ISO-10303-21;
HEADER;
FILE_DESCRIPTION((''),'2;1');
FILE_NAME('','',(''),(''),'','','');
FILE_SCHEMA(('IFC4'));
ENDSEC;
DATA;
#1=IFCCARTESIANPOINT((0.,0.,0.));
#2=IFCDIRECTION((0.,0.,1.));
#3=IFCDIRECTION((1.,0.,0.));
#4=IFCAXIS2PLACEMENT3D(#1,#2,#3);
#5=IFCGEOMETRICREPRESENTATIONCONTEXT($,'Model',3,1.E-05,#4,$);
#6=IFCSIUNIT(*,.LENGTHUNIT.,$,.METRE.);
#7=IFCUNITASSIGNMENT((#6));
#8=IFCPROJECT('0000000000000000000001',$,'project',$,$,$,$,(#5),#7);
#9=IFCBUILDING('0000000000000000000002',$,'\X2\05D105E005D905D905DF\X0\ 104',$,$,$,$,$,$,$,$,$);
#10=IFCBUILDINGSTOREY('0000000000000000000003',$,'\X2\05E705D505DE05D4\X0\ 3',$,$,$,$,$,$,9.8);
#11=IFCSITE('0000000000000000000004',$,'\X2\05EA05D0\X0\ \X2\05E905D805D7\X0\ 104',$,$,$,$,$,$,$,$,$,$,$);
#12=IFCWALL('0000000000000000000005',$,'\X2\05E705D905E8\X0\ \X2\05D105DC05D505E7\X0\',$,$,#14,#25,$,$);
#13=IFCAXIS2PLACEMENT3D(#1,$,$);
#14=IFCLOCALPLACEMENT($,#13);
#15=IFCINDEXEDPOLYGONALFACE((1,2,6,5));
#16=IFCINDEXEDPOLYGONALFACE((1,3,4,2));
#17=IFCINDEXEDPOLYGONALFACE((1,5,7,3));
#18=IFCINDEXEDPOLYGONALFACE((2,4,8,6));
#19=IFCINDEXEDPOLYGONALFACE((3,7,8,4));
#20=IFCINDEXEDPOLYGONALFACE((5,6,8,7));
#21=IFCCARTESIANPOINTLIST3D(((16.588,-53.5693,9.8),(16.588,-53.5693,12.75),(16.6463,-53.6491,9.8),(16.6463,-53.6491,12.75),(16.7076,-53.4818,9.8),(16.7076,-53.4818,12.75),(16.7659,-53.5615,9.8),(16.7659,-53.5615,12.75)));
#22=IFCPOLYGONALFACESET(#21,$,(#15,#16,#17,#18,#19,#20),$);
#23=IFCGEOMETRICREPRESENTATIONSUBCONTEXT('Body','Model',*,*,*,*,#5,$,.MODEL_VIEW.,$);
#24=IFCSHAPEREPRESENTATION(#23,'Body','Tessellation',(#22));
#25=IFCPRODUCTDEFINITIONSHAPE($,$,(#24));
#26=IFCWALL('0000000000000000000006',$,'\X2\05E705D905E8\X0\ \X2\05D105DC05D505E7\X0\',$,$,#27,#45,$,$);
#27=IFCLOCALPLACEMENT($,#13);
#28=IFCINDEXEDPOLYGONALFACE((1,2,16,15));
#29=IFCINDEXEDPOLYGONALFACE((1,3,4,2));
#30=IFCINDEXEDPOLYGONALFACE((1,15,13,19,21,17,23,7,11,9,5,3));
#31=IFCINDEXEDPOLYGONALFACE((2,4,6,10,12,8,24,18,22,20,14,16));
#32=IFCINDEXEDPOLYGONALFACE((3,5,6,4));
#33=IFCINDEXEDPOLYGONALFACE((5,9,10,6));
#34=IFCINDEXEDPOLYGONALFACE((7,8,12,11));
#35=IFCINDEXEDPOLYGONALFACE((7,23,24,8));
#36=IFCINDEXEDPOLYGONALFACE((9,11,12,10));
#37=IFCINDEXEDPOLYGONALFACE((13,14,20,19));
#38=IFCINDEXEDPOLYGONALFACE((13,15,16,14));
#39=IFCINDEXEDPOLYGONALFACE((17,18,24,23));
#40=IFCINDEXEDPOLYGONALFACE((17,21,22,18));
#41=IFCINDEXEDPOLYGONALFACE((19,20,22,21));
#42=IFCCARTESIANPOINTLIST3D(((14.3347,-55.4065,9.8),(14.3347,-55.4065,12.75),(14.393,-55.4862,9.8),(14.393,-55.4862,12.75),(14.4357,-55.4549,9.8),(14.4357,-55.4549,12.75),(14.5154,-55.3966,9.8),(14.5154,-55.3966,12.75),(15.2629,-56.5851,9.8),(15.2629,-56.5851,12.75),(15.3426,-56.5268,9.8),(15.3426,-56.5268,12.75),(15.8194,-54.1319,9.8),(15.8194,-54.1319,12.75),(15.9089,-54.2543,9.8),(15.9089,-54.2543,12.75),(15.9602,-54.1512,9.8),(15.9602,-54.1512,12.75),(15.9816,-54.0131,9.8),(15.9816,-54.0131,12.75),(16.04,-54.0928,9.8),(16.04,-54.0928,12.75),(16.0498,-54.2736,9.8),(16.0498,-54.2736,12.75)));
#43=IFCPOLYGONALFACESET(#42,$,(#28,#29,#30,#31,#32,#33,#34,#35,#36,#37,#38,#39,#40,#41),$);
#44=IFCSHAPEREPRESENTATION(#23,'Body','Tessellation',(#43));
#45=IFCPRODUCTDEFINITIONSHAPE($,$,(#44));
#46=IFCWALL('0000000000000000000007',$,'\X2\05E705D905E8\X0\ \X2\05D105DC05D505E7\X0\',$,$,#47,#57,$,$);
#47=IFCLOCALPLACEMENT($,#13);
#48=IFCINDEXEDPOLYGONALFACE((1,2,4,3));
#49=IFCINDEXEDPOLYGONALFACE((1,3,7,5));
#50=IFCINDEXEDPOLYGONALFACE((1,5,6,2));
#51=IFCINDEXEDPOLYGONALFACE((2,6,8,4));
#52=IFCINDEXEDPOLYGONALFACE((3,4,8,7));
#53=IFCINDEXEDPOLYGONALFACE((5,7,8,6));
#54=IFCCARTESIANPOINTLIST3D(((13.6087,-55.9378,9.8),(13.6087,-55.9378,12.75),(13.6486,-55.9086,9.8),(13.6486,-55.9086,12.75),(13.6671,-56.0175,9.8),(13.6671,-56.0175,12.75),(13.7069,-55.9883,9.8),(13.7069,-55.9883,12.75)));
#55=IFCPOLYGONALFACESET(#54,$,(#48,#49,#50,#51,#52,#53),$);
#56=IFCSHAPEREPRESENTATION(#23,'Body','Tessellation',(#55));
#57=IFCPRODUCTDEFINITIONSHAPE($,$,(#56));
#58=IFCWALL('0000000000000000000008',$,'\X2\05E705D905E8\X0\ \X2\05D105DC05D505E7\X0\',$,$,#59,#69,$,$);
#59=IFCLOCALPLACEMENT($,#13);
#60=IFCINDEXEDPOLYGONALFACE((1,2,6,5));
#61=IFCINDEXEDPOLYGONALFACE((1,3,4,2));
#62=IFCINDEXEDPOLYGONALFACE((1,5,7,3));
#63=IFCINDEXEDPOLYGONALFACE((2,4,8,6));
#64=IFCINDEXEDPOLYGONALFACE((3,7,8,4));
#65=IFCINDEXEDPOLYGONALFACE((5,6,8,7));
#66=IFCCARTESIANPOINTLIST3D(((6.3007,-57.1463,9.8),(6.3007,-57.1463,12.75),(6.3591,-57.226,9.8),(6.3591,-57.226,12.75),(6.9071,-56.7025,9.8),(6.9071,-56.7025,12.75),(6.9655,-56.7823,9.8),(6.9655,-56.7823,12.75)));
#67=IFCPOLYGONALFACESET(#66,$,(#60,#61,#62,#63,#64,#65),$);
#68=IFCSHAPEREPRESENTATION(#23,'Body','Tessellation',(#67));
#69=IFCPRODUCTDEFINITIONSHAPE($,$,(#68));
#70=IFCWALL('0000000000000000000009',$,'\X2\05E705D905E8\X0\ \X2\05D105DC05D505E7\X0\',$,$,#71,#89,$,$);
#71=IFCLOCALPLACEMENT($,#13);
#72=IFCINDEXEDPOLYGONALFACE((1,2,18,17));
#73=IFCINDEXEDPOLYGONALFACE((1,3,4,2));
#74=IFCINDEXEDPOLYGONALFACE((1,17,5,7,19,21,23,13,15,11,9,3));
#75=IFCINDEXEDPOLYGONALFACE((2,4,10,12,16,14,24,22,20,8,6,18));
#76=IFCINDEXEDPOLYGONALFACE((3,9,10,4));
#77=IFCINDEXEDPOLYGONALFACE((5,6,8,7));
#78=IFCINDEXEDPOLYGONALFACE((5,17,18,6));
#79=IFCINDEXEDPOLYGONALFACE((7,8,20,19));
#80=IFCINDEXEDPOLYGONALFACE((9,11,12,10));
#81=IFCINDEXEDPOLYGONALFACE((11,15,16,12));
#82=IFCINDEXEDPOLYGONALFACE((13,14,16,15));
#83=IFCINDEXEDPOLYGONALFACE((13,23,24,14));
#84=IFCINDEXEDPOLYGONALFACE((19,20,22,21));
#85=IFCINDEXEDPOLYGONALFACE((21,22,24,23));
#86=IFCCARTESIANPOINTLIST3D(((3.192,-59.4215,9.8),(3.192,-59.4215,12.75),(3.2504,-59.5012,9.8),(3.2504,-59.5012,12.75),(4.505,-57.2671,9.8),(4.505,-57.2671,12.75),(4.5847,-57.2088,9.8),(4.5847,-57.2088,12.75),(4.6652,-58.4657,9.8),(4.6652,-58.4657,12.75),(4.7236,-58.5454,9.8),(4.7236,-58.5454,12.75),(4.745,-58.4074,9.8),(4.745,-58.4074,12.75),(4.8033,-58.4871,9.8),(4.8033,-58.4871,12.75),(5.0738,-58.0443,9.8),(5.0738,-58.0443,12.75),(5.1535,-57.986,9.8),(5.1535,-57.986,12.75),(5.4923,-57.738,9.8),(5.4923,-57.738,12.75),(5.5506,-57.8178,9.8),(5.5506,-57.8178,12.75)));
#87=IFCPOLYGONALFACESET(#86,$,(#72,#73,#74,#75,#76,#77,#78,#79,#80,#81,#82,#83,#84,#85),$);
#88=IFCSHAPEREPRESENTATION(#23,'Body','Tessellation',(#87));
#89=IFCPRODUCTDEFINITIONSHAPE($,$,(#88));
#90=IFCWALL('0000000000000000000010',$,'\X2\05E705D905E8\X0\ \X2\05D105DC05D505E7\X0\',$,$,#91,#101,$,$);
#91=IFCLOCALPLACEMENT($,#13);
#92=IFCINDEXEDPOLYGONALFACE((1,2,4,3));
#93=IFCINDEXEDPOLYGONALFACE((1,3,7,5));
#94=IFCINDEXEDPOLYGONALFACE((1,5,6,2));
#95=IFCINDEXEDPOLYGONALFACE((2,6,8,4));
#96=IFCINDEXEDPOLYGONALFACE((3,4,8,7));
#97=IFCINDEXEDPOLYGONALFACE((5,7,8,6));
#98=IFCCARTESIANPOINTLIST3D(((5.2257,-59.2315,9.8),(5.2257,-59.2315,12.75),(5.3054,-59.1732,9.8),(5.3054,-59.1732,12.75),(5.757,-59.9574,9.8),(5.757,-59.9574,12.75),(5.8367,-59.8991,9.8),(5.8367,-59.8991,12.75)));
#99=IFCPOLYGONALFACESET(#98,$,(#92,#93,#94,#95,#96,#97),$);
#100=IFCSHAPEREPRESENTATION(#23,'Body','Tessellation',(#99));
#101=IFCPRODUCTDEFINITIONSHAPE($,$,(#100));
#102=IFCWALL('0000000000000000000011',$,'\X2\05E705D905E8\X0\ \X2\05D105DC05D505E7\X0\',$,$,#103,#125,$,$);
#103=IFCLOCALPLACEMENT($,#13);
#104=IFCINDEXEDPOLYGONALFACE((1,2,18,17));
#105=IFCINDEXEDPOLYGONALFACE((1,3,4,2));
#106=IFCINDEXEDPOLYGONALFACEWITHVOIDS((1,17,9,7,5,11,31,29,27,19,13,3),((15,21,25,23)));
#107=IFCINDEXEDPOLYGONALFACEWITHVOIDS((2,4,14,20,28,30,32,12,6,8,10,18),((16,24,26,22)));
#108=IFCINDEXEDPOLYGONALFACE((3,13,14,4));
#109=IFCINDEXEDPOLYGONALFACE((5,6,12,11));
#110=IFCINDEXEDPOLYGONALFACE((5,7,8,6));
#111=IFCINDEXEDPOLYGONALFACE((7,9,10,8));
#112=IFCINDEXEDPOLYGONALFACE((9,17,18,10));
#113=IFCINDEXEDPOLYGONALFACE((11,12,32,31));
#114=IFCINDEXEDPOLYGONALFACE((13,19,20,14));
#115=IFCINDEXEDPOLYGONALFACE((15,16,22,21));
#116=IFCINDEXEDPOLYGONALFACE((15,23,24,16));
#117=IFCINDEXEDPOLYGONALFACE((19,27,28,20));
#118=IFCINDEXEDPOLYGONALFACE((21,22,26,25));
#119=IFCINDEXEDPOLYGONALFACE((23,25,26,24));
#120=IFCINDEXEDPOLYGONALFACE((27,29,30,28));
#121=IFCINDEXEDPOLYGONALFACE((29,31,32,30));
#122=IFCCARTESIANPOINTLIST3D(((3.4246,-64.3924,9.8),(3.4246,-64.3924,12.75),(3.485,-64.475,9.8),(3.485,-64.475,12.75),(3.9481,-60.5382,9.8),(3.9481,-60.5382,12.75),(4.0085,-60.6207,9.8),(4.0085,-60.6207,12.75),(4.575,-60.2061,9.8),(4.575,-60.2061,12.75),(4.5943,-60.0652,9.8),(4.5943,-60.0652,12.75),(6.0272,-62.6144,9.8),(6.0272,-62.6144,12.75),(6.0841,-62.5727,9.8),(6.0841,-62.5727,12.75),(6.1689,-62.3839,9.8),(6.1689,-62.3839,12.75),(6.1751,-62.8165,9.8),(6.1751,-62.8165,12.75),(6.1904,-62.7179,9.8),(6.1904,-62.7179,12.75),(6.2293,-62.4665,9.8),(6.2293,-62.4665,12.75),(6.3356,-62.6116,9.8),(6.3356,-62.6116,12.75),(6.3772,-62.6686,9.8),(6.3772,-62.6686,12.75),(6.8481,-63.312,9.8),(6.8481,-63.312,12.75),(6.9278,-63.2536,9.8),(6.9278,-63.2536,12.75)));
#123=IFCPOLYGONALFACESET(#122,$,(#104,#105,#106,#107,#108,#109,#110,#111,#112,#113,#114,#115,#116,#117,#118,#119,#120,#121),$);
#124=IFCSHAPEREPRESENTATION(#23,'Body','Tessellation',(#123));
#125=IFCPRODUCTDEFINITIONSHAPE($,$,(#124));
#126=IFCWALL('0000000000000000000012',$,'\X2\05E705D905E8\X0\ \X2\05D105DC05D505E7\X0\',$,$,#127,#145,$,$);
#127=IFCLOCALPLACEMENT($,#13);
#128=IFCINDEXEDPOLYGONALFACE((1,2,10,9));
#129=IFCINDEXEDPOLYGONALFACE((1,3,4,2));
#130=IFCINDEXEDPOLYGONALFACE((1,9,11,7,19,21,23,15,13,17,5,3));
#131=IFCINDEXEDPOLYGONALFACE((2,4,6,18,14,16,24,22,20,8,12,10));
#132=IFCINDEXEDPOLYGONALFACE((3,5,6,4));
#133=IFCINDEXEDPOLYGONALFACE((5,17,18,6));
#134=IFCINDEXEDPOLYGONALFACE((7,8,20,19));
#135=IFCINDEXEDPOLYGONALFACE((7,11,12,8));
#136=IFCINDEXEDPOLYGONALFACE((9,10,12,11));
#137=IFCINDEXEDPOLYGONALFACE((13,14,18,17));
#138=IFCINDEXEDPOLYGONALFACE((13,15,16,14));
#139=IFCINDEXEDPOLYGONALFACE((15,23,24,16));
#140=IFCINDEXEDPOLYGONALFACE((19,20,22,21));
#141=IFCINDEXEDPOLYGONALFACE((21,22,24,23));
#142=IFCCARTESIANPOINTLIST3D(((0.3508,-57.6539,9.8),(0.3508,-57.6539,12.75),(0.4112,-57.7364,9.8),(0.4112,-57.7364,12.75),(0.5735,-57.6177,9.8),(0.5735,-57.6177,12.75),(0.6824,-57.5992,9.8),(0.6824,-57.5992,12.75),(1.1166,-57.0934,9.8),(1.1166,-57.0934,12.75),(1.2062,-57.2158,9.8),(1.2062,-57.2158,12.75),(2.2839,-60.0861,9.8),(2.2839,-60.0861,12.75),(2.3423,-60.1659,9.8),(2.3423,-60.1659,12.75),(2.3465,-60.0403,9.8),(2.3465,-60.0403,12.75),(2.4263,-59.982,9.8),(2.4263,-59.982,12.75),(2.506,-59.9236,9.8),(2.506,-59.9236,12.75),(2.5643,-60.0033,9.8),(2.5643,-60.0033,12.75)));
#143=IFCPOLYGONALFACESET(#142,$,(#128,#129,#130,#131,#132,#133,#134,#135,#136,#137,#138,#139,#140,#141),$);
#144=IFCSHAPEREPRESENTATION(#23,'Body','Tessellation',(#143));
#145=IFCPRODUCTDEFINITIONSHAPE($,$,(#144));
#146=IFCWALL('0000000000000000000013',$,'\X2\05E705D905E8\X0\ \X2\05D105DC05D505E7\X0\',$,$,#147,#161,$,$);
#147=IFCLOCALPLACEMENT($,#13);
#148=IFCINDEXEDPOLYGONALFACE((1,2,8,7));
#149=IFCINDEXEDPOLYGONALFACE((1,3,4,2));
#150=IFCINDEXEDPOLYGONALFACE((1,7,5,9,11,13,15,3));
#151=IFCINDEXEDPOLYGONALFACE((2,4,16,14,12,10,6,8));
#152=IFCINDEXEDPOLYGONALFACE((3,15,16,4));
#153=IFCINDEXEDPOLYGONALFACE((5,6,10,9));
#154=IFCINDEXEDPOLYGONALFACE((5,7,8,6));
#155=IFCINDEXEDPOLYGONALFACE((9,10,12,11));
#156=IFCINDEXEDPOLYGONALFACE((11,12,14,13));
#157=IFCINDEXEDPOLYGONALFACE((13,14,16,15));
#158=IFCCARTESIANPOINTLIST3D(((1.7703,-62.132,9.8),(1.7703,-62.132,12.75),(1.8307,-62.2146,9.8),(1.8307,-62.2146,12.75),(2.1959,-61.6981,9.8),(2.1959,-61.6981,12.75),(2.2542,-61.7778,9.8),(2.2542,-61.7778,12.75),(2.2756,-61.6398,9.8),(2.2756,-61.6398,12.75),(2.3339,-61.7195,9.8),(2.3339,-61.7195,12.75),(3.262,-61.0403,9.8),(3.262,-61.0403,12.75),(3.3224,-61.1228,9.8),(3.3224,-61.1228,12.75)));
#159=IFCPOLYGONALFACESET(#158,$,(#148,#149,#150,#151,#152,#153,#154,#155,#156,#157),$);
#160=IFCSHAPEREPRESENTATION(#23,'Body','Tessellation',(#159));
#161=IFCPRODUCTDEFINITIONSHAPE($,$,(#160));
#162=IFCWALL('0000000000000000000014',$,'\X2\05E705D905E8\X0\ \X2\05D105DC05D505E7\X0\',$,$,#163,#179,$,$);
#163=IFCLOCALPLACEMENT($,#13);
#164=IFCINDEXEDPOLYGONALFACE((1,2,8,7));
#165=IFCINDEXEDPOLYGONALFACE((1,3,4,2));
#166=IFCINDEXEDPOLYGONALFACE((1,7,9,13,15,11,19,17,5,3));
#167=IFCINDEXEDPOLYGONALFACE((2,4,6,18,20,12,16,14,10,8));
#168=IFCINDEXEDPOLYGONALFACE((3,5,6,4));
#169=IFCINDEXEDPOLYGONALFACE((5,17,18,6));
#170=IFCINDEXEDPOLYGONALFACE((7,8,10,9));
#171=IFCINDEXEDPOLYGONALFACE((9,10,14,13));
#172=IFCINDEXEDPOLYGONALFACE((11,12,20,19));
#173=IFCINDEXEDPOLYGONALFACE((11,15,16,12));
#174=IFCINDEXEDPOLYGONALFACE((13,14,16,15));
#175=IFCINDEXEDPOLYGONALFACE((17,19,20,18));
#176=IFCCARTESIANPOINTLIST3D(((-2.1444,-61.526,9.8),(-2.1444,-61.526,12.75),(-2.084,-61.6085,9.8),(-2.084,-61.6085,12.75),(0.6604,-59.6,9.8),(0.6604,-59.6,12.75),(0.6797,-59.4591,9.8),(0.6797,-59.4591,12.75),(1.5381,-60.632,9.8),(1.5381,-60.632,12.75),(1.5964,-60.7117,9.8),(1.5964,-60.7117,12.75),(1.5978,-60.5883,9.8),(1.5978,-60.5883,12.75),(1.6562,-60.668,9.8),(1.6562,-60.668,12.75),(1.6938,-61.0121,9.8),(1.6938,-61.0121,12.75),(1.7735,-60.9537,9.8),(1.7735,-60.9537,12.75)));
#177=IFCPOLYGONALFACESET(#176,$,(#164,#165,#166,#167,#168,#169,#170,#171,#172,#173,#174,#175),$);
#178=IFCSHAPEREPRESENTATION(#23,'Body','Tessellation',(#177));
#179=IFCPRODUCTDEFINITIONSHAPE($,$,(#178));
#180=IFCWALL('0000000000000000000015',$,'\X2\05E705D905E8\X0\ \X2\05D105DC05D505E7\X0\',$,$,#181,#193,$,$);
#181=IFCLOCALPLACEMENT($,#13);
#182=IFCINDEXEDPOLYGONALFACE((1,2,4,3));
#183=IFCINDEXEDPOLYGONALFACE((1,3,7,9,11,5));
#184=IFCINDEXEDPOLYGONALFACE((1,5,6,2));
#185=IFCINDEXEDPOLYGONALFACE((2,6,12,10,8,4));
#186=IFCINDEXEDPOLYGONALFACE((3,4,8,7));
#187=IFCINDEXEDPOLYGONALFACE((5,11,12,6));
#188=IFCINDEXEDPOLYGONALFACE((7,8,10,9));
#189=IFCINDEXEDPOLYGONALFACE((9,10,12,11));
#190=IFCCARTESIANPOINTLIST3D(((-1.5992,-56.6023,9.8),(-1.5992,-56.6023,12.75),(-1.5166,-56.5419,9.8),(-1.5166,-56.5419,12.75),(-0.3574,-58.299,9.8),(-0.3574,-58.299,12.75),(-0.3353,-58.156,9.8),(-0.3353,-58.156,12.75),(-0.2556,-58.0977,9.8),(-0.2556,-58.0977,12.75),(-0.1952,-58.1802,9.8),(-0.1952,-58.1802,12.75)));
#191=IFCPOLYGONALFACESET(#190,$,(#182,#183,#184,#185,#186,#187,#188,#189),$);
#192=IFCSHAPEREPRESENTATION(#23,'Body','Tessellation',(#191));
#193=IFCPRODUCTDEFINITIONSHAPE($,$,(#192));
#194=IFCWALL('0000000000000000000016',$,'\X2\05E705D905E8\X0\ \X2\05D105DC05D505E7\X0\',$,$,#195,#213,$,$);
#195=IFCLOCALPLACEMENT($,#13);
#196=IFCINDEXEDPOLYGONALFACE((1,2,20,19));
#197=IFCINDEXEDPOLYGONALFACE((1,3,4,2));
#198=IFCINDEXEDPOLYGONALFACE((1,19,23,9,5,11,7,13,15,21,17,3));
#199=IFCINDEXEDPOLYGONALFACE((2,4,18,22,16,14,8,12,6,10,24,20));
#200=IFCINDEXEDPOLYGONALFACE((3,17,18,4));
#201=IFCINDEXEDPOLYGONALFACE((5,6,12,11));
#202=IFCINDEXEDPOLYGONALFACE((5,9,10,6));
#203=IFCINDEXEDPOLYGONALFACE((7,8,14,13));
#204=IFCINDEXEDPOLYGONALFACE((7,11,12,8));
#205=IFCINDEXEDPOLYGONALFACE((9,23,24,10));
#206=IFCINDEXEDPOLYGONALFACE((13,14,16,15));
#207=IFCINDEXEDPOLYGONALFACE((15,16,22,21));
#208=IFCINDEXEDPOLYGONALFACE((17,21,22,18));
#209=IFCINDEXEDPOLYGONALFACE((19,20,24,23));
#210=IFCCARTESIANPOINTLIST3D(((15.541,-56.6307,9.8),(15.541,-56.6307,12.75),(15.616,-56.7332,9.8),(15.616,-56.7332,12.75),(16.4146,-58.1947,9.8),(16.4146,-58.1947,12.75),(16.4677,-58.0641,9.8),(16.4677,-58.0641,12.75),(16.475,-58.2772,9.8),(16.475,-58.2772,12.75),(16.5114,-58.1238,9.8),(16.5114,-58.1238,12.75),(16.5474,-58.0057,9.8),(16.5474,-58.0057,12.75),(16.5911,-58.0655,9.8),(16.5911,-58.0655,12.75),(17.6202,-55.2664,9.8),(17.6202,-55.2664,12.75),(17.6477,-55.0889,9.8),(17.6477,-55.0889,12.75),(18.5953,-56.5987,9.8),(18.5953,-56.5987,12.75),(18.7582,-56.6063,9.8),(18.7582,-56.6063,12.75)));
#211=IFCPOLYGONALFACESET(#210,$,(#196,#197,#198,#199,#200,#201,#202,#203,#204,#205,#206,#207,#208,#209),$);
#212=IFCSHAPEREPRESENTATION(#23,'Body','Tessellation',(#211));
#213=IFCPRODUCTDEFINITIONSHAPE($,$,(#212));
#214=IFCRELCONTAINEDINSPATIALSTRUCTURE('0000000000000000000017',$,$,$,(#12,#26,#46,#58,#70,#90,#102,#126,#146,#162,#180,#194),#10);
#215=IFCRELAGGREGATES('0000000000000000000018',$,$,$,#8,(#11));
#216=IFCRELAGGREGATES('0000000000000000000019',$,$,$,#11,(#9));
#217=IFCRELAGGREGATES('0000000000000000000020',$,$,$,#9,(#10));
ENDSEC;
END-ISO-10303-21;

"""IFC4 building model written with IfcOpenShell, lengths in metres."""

from ifc_helpers import new_model, si_unit, frame, origin_with_axes, context, subcontext, project, spatial, polyline, outline, extrude, element, save


model = new_model("IFC4")

# Units and contexts
model_context = context("Model", 3, precision=1e-05, world=origin_with_axes())
body_context = subcontext(model_context, "Body", "Model", "MODEL_VIEW")
ifc_project = project(units=[si_unit("LENGTHUNIT", "METRE")], contexts=[model_context])

# Site, building, storey
site = spatial("IfcSite", under=ifc_project, Name="תא שטח 104")
building = spatial("IfcBuilding", under=site, Name="בניין 104")
storey = spatial("IfcBuildingStorey", under=building, Name="קומה 3", Elevation=9.8)

# Walls
element("IfcWall", 1, inside=storey, Name="קיר בלוק", context=body_context, shape_type="SweptSolid", body=[
    extrude(outline(polyline([(16.6463, -53.6491), (16.7659, -53.5615), (16.7076, -53.4818), (16.588, -53.5693), (16.6463, -53.6491)])), frame((0.0, 0.0, 9.8)), (0.0, 0.0, 1.0), 2.95),
])
element("IfcWall", 2, inside=storey, Name="קיר בלוק", context=body_context, shape_type="SweptSolid", body=[
    extrude(outline(polyline([(15.8194, -54.1319), (15.9089, -54.2543), (14.3347, -55.4065), (14.393, -55.4862), (14.4357, -55.4549), (15.2629, -56.5851), (15.3426, -56.5268), (14.5154, -55.3966), (16.0498, -54.2736), (15.9602, -54.1512), (16.04, -54.0928), (15.9816, -54.0131), (15.8194, -54.1319)])), frame((0.0, 0.0, 9.8)), (0.0, 0.0, 1.0), 2.95),
])
element("IfcWall", 3, inside=storey, Name="קיר בלוק", context=body_context, shape_type="SweptSolid", body=[
    extrude(outline(polyline([(13.7069, -55.9883), (13.6486, -55.9086), (13.6087, -55.9378), (13.6671, -56.0175), (13.7069, -55.9883)])), frame((0.0, 0.0, 9.8)), (0.0, 0.0, 1.0), 2.95),
])
element("IfcWall", 4, inside=storey, Name="קיר בלוק", context=body_context, shape_type="SweptSolid", body=[
    extrude(outline(polyline([(6.3591, -57.226), (6.9655, -56.7823), (6.9071, -56.7025), (6.3007, -57.1463), (6.3591, -57.226)])), frame((0.0, 0.0, 9.8)), (0.0, 0.0, 1.0), 2.95),
])
element("IfcWall", 5, inside=storey, Name="קיר בלוק", context=body_context, shape_type="SweptSolid", body=[
    extrude(outline(polyline([(3.192, -59.4215), (3.2504, -59.5012), (4.6652, -58.4657), (4.7236, -58.5454), (4.8033, -58.4871), (4.745, -58.4074), (5.5506, -57.8178), (5.4923, -57.738), (5.1535, -57.986), (4.5847, -57.2088), (4.505, -57.2671), (5.0738, -58.0443), (3.192, -59.4215)])), frame((0.0, 0.0, 9.8)), (0.0, 0.0, 1.0), 2.95),
])
element("IfcWall", 6, inside=storey, Name="קיר בלוק", context=body_context, shape_type="SweptSolid", body=[
    extrude(outline(polyline([(5.8367, -59.8991), (5.3054, -59.1732), (5.2257, -59.2315), (5.757, -59.9574), (5.8367, -59.8991)])), frame((0.0, 0.0, 9.8)), (0.0, 0.0, 1.0), 2.95),
])
element("IfcWall", 7, inside=storey, Name="קיר בלוק", context=body_context, shape_type="SweptSolid", body=[
    extrude(outline(polyline([(3.485, -64.475), (6.0272, -62.6144), (6.1751, -62.8165), (6.3772, -62.6686), (6.8481, -63.312), (6.9278, -63.2536), (4.5943, -60.0652), (3.9481, -60.5382), (4.0085, -60.6207), (4.575, -60.2061), (6.1689, -62.3839), (3.4246, -64.3924), (3.485, -64.475)]), holes=[polyline([(6.1904, -62.7179), (6.0841, -62.5727), (6.2293, -62.4665), (6.3356, -62.6116), (6.1904, -62.7179)])]), frame((0.0, 0.0, 9.8)), (0.0, 0.0, 1.0), 2.95),
])
element("IfcWall", 8, inside=storey, Name="קיר בלוק", context=body_context, shape_type="SweptSolid", body=[
    extrude(outline(polyline([(2.2839, -60.0861), (2.3423, -60.1659), (2.5643, -60.0033), (2.506, -59.9236), (2.4263, -59.982), (0.6824, -57.5992), (1.2062, -57.2158), (1.1166, -57.0934), (0.3508, -57.6539), (0.4112, -57.7364), (0.5735, -57.6177), (2.3465, -60.0403), (2.2839, -60.0861)])), frame((0.0, 0.0, 9.8)), (0.0, 0.0, 1.0), 2.95),
])
element("IfcWall", 9, inside=storey, Name="קיר בלוק", context=body_context, shape_type="SweptSolid", body=[
    extrude(outline(polyline([(2.1959, -61.6981), (2.2542, -61.7778), (1.7703, -62.132), (1.8307, -62.2146), (3.3224, -61.1228), (3.262, -61.0403), (2.3339, -61.7195), (2.2756, -61.6398), (2.1959, -61.6981)])), frame((0.0, 0.0, 9.8)), (0.0, 0.0, 1.0), 2.95),
])
element("IfcWall", 10, inside=storey, Name="קיר בלוק", context=body_context, shape_type="SweptSolid", body=[
    extrude(outline(polyline([(1.7735, -60.9537), (1.5964, -60.7117), (1.6562, -60.668), (1.5978, -60.5883), (1.5381, -60.632), (0.6797, -59.4591), (-2.1444, -61.526), (-2.084, -61.6085), (0.6604, -59.6), (1.6938, -61.0121), (1.7735, -60.9537)])), frame((0.0, 0.0, 9.8)), (0.0, 0.0, 1.0), 2.95),
])
element("IfcWall", 11, inside=storey, Name="קיר בלוק", context=body_context, shape_type="SweptSolid", body=[
    extrude(outline(polyline([(-1.5992, -56.6023), (-0.3574, -58.299), (-0.1952, -58.1802), (-0.2556, -58.0977), (-0.3353, -58.156), (-1.5166, -56.5419), (-1.5992, -56.6023)])), frame((0.0, 0.0, 9.8)), (0.0, 0.0, 1.0), 2.95),
])
element("IfcWall", 12, inside=storey, Name="קיר בלוק", context=body_context, shape_type="SweptSolid", body=[
    extrude(outline(polyline([(15.616, -56.7332), (17.6202, -55.2664), (18.5953, -56.5987), (16.5911, -58.0655), (16.5474, -58.0057), (16.4677, -58.0641), (16.5114, -58.1238), (16.4146, -58.1947), (16.475, -58.2772), (18.7582, -56.6063), (17.6477, -55.0889), (15.541, -56.6307), (15.616, -56.7332)])), frame((0.0, 0.0, 9.8)), (0.0, 0.0, 1.0), 2.95),
])

save(model, "model.ifc")
